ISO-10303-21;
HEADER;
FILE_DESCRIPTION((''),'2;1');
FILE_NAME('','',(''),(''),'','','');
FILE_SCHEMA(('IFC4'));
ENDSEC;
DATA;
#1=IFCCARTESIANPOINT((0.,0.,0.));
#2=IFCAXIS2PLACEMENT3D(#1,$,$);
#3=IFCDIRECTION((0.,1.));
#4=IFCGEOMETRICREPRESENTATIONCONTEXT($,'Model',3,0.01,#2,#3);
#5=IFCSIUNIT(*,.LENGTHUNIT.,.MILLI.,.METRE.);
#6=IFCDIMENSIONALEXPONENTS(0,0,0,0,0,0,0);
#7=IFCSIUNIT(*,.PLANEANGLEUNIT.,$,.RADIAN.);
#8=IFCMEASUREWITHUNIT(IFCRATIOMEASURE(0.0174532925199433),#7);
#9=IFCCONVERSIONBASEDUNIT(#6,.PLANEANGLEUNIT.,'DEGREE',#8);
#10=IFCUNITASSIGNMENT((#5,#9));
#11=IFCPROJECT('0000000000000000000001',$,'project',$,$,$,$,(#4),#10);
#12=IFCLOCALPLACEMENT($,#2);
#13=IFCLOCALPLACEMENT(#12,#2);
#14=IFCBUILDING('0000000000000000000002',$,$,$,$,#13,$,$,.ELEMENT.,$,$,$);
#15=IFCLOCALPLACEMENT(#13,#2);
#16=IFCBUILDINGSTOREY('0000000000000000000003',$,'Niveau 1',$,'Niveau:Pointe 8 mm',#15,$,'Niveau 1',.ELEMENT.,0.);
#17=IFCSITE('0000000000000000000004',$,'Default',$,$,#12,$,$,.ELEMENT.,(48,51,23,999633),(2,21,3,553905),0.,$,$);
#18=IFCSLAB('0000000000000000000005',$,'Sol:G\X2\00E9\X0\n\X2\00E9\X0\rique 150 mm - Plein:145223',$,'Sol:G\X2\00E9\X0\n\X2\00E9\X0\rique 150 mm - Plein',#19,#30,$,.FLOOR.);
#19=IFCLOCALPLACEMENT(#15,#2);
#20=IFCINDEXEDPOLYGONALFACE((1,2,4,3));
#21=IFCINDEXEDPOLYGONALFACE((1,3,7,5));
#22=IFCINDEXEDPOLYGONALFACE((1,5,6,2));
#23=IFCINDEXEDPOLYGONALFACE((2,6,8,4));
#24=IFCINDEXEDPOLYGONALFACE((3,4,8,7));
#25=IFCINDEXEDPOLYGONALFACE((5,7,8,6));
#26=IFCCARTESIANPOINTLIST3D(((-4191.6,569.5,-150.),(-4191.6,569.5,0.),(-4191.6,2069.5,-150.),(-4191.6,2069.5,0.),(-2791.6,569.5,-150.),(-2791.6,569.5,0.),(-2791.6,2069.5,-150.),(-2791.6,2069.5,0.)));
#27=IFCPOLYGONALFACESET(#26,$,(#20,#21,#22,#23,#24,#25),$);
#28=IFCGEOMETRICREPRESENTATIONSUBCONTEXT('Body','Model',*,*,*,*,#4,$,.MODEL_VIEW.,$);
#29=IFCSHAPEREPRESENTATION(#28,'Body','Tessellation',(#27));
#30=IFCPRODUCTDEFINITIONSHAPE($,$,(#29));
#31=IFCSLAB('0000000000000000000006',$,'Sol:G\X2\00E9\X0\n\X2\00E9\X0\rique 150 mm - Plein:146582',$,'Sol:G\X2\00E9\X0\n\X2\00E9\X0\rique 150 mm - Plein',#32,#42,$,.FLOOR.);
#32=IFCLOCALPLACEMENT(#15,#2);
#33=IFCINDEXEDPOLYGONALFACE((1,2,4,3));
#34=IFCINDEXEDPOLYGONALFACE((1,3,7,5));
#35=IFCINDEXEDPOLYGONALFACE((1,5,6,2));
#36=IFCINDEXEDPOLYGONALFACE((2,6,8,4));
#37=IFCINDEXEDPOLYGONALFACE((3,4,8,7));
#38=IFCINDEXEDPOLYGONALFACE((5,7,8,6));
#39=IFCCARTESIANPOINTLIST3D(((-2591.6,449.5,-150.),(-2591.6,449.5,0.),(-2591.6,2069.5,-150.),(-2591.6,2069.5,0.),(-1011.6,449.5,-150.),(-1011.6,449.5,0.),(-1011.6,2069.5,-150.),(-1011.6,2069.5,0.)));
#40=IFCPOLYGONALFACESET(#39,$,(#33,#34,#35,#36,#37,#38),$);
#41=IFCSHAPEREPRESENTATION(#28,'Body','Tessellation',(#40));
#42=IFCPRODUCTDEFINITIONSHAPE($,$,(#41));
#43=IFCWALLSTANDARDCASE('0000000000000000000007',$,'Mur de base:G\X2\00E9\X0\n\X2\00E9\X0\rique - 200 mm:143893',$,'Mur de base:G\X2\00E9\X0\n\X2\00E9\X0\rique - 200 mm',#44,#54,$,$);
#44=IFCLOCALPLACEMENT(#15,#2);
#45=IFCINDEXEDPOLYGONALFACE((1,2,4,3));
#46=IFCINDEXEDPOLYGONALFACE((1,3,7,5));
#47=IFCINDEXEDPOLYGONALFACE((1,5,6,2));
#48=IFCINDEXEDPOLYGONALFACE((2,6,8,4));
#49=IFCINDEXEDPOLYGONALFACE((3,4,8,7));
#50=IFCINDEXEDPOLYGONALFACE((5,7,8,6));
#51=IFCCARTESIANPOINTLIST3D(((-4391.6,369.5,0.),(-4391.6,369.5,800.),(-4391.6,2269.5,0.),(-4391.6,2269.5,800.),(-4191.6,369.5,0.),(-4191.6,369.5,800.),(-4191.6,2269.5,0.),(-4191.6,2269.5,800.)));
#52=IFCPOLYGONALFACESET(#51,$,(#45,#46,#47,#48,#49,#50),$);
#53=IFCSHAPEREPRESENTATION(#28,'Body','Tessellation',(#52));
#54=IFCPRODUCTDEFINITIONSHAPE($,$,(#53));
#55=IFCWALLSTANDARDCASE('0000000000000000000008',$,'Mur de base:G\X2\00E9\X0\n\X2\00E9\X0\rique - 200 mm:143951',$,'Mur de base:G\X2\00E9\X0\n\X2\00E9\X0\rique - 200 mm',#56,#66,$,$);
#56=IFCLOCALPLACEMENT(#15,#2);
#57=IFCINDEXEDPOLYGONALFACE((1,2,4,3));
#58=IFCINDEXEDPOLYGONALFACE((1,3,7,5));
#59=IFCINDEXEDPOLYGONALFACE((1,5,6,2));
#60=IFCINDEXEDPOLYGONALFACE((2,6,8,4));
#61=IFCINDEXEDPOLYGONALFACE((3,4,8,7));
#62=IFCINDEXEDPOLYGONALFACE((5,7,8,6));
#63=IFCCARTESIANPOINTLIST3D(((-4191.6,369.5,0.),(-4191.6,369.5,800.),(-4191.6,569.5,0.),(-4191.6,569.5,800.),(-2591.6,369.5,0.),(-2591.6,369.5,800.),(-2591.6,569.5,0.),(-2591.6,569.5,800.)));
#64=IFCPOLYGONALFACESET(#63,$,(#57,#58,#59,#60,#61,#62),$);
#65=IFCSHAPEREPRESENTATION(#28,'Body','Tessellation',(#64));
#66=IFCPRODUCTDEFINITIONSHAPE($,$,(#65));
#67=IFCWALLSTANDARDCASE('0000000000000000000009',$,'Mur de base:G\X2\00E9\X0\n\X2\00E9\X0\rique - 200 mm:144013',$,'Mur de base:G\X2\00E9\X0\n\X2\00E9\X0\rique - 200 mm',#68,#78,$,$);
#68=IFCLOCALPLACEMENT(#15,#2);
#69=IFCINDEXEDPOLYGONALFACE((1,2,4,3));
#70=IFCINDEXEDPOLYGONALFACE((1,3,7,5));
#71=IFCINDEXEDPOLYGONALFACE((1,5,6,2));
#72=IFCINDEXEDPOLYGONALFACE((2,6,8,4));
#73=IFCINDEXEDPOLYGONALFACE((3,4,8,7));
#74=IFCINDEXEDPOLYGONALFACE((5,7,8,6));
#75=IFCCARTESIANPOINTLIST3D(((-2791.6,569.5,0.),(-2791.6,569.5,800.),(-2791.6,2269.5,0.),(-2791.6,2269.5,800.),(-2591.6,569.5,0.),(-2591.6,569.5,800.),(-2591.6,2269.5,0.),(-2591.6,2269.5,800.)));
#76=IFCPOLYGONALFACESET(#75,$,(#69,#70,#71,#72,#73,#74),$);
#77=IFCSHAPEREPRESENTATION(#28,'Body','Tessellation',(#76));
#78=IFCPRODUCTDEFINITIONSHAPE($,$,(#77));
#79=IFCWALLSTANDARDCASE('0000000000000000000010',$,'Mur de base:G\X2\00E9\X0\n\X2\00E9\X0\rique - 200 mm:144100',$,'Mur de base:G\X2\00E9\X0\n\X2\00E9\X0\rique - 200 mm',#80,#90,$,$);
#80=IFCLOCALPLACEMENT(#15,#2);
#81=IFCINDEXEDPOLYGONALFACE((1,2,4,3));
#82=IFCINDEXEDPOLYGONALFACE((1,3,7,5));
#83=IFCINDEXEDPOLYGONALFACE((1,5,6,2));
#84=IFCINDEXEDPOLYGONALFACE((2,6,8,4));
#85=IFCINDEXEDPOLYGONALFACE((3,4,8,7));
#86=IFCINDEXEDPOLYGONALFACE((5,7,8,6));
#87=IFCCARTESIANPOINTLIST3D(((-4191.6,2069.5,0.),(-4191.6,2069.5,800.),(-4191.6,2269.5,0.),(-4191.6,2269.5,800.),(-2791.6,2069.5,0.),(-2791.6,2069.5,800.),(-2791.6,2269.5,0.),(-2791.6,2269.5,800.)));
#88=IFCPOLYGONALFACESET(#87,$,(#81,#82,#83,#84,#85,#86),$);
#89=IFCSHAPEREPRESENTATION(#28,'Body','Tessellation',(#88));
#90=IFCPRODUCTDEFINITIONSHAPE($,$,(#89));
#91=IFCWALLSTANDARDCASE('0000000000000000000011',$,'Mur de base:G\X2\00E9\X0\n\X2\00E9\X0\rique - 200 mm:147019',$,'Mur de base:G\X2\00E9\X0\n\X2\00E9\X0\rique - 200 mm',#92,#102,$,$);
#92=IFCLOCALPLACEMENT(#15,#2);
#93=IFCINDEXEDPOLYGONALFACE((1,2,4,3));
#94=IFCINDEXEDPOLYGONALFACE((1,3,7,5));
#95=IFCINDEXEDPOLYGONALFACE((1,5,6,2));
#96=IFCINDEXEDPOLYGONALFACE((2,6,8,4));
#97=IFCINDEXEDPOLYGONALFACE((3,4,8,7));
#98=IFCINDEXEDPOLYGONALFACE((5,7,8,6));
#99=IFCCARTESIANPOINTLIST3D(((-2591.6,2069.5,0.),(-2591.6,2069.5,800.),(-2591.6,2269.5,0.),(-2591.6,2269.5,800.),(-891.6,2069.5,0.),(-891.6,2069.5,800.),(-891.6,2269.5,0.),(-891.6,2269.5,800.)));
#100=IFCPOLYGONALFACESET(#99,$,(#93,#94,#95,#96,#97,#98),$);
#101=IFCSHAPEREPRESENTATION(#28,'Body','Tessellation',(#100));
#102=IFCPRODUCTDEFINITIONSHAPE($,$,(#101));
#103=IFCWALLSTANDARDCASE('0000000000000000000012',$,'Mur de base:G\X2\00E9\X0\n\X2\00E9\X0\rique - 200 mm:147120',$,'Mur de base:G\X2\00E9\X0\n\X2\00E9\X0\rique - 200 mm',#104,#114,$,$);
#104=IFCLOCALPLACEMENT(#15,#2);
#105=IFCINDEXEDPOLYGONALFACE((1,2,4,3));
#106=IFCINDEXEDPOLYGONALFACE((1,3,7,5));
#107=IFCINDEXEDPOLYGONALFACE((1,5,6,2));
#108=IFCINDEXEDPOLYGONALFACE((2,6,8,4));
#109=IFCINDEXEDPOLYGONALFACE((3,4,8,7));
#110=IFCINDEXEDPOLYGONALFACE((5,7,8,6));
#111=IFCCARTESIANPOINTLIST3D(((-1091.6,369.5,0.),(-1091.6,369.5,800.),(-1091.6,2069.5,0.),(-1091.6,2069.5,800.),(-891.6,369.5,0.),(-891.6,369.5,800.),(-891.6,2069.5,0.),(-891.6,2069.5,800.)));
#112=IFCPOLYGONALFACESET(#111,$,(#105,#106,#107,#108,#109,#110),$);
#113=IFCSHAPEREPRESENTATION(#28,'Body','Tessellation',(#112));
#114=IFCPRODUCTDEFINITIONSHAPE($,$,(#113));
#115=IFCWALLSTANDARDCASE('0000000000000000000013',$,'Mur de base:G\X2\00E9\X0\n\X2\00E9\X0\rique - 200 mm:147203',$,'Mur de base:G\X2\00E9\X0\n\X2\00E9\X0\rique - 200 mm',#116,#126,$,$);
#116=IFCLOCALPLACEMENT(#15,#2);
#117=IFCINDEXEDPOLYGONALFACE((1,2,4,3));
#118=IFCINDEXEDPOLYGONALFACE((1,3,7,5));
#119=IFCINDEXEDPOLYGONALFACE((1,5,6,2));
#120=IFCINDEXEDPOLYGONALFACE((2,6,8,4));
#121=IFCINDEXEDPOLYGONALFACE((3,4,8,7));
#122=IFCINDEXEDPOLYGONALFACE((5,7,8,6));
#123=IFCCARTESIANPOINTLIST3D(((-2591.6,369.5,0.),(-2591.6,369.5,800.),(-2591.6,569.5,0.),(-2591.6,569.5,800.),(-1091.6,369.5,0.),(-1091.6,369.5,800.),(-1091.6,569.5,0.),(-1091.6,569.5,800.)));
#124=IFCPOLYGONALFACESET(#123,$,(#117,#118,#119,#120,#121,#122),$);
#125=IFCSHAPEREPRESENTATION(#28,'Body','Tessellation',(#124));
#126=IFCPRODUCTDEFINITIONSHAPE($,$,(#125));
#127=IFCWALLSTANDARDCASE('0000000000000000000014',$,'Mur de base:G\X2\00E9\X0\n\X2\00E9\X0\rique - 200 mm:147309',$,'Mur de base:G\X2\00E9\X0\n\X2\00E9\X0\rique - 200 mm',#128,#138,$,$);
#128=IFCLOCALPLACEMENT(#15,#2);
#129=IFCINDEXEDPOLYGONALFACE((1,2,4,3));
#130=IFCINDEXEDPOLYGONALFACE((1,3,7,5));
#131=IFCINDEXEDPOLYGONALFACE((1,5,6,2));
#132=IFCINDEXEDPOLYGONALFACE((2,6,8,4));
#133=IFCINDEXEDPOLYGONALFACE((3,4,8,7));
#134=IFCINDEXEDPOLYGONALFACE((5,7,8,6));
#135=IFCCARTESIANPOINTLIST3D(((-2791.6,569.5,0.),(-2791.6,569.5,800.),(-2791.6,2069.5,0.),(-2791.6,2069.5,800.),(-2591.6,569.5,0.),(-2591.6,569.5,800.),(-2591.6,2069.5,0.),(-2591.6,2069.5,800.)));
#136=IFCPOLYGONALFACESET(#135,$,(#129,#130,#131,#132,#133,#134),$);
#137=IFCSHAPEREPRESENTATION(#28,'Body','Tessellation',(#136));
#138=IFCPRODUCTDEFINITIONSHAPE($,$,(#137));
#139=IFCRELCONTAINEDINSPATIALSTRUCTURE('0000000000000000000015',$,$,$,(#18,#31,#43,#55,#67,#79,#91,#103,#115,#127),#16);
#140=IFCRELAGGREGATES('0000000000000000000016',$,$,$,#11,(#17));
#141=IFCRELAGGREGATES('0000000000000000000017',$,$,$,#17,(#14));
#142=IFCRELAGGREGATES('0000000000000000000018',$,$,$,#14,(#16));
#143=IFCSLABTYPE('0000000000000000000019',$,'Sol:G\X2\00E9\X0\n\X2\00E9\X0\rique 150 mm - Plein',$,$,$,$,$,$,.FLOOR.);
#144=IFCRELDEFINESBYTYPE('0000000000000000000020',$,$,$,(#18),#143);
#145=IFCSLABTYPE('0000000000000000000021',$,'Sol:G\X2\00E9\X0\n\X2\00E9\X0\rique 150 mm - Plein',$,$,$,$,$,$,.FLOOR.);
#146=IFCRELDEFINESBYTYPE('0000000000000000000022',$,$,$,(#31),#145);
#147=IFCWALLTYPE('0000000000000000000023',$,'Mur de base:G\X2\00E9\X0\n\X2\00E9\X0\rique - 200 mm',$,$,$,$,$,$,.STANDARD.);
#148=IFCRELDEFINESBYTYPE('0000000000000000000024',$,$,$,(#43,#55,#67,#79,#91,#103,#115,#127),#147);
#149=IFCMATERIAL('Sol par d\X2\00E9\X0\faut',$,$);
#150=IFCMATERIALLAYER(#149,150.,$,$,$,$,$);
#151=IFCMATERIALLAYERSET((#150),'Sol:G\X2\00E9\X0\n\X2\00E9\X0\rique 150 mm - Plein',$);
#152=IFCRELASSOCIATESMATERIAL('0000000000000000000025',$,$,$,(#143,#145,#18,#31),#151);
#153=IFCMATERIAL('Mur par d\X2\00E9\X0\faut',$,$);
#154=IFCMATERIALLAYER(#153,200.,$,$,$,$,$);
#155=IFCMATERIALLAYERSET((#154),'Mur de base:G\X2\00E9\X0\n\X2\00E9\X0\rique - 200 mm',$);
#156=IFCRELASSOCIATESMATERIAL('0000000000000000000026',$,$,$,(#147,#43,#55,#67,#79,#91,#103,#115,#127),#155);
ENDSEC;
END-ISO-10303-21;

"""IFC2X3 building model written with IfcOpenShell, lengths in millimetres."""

from ifc_helpers import new_model, entity, si_unit, converted_unit, direction, frame, frame_2d, origin, origin_2d_with_axis, place, context, subcontext, project, spatial, rectangle, extrude, material, layer, layer_set, layer_usage, type_object, element, save


model = new_model("IFC2X3")

# Units and contexts
model_context = context("Model", 3, precision=0.01, world=origin(), true_north=direction((0.0, 1.0)))
body_context = subcontext(model_context, "Body", "Model", "MODEL_VIEW")
ifc_project = project(units=[si_unit("LENGTHUNIT", "METRE", prefix="MILLI"), converted_unit("PLANEANGLEUNIT", "DEGREE", entity("IfcRatioMeasure", 0.0174532925199433), si_unit("PLANEANGLEUNIT", "RADIAN"), dimensions=[0, 0, 0, 0, 0, 0, 0])], contexts=[model_context])

# Site, building, storey
site_placement = place(None, origin())
site = spatial("IfcSite", under=ifc_project, at=site_placement, Name="Default", CompositionType="ELEMENT", RefLatitude=(48, 51, 23, 999633), RefLongitude=(2, 21, 3, 553905), RefElevation=0.0)
building_placement = place(site_placement, origin())
building = spatial("IfcBuilding", under=site, at=building_placement, CompositionType="ELEMENT")
storey_placement = place(building_placement, origin())
storey = spatial("IfcBuildingStorey", under=building, at=storey_placement, Name="Niveau 1", ObjectType="Niveau:Pointe 8 mm", LongName="Niveau 1", CompositionType="ELEMENT", Elevation=0.0)

# Slabs
ifc_material_1 = material(Name="Sol par défaut")
ifc_layer_1 = layer(ifc_material_1, 150.0)
ifc_layer_set_1 = layer_set([ifc_layer_1], Name="Sol:Générique 150 mm - Plein")
ifc_layer_usage_1 = layer_usage(ifc_layer_set_1, "AXIS3", "POSITIVE", 0.0)
slab_type_1 = type_object("IfcSlabType", Name="Sol:Générique 150 mm - Plein", PredefinedType="FLOOR", material=ifc_layer_set_1)
slab_1_placement = place(storey_placement, origin())
element("IfcSlab", 1, at=slab_1_placement, inside=storey, type_object=slab_type_1, material=ifc_layer_usage_1, Name="Sol:Générique 150 mm - Plein:145223", ObjectType="Sol:Générique 150 mm - Plein", PredefinedType="FLOOR", context=body_context, shape_type="SweptSolid", body=[
    extrude(rectangle(XDim=1500.0, YDim=1400.0, at=frame_2d((0.0, 0.0), x_axis=(1.0, 0.0))), frame((-3491.6, 1319.5, 0.0), z_axis=(0.0, 0.0, -1.0), x_axis=(0.0, 1.0, 0.0)), (0.0, 0.0, 1.0), 150.0),
])
ifc_layer_usage_2 = layer_usage(ifc_layer_set_1, "AXIS3", "POSITIVE", 0.0)
slab_type_2 = type_object("IfcSlabType", Name="Sol:Générique 150 mm - Plein", PredefinedType="FLOOR", material=ifc_layer_set_1)
slab_2_placement = place(storey_placement, origin())
element("IfcSlab", 2, at=slab_2_placement, inside=storey, type_object=slab_type_2, material=ifc_layer_usage_2, Name="Sol:Générique 150 mm - Plein:146582", ObjectType="Sol:Générique 150 mm - Plein", PredefinedType="FLOOR", context=body_context, shape_type="SweptSolid", body=[
    extrude(rectangle(XDim=1620.0, YDim=1580.0, at=origin_2d_with_axis()), frame((-1801.6, 1259.5, 0.0), z_axis=(0.0, 0.0, -1.0), x_axis=(0.0, 1.0, 0.0)), (0.0, 0.0, 1.0), 150.0),
])

# Walls
ifc_material_2 = material(Name="Mur par défaut")
ifc_layer_2 = layer(ifc_material_2, 200.0)
ifc_layer_set_2 = layer_set([ifc_layer_2], Name="Mur de base:Générique - 200 mm")
ifc_layer_usage_3 = layer_usage(ifc_layer_set_2, "AXIS2", "NEGATIVE", 100.0)
wall_type = type_object("IfcWallType", Name="Mur de base:Générique - 200 mm", PredefinedType="STANDARD", material=ifc_layer_set_2)
wall_1_placement = place(storey_placement, frame((-4291.6, 2269.5, 0.0), z_axis=(0.0, 0.0, 1.0), x_axis=(0.0, -1.0, 0.0)))
element("IfcWallStandardCase", 3, at=wall_1_placement, inside=storey, type_object=wall_type, material=ifc_layer_usage_3, Name="Mur de base:Générique - 200 mm:143893", ObjectType="Mur de base:Générique - 200 mm", context=body_context, shape_type="SweptSolid", body=[
    extrude(rectangle(XDim=1900.0, YDim=200.0, at=frame_2d((950.0, 0.0), x_axis=(-1.0, 0.0))), origin(), (0.0, 0.0, 1.0), 800.0),
])
ifc_layer_usage_4 = layer_usage(ifc_layer_set_2, "AXIS2", "NEGATIVE", 100.0)
wall_2_placement = place(storey_placement, frame((-4191.6, 469.5, 0.0)))
element("IfcWallStandardCase", 4, at=wall_2_placement, inside=storey, type_object=wall_type, material=ifc_layer_usage_4, Name="Mur de base:Générique - 200 mm:143951", ObjectType="Mur de base:Générique - 200 mm", context=body_context, shape_type="SweptSolid", body=[
    extrude(rectangle(XDim=1600.0, YDim=200.0, at=frame_2d((800.0, 0.0), x_axis=(-1.0, 0.0))), origin(), (0.0, 0.0, 1.0), 800.0),
])
ifc_layer_usage_5 = layer_usage(ifc_layer_set_2, "AXIS2", "NEGATIVE", 100.0)
wall_3_placement = place(storey_placement, frame((-2691.6, 569.5, 0.0), z_axis=(0.0, 0.0, 1.0), x_axis=(0.0, 1.0, 0.0)))
element("IfcWallStandardCase", 5, at=wall_3_placement, inside=storey, type_object=wall_type, material=ifc_layer_usage_5, Name="Mur de base:Générique - 200 mm:144013", ObjectType="Mur de base:Générique - 200 mm", context=body_context, shape_type="SweptSolid", body=[
    extrude(rectangle(XDim=1700.0, YDim=200.0, at=frame_2d((850.0, 0.0), x_axis=(-1.0, 0.0))), origin(), (0.0, 0.0, 1.0), 800.0),
])
ifc_layer_usage_6 = layer_usage(ifc_layer_set_2, "AXIS2", "NEGATIVE", 100.0)
wall_4_placement = place(storey_placement, frame((-2791.6, 2169.5, 0.0), z_axis=(0.0, 0.0, 1.0), x_axis=(-1.0, 0.0, 0.0)))
element("IfcWallStandardCase", 6, at=wall_4_placement, inside=storey, type_object=wall_type, material=ifc_layer_usage_6, Name="Mur de base:Générique - 200 mm:144100", ObjectType="Mur de base:Générique - 200 mm", context=body_context, shape_type="SweptSolid", body=[
    extrude(rectangle(XDim=1400.0, YDim=200.0, at=frame_2d((700.0, 0.0), x_axis=(-1.0, 0.0))), origin(), (0.0, 0.0, 1.0), 800.0),
])
ifc_layer_usage_7 = layer_usage(ifc_layer_set_2, "AXIS2", "NEGATIVE", 100.0)
wall_5_placement = place(storey_placement, frame((-2591.6, 2169.5, 0.0)))
element("IfcWallStandardCase", 7, at=wall_5_placement, inside=storey, type_object=wall_type, material=ifc_layer_usage_7, Name="Mur de base:Générique - 200 mm:147019", ObjectType="Mur de base:Générique - 200 mm", context=body_context, shape_type="SweptSolid", body=[
    extrude(rectangle(XDim=1700.0, YDim=200.0, at=frame_2d((850.0, 0.0), x_axis=(-1.0, 0.0))), origin(), (0.0, 0.0, 1.0), 800.0),
])
ifc_layer_usage_8 = layer_usage(ifc_layer_set_2, "AXIS2", "NEGATIVE", 100.0)
wall_6_placement = place(storey_placement, frame((-991.6, 2069.5, 0.0), z_axis=(0.0, 0.0, 1.0), x_axis=(0.0, -1.0, 0.0)))
element("IfcWallStandardCase", 8, at=wall_6_placement, inside=storey, type_object=wall_type, material=ifc_layer_usage_8, Name="Mur de base:Générique - 200 mm:147120", ObjectType="Mur de base:Générique - 200 mm", context=body_context, shape_type="SweptSolid", body=[
    extrude(rectangle(XDim=1700.0, YDim=200.0, at=frame_2d((850.0, 0.0), x_axis=(-1.0, 0.0))), origin(), (0.0, 0.0, 1.0), 800.0),
])
ifc_layer_usage_9 = layer_usage(ifc_layer_set_2, "AXIS2", "NEGATIVE", 100.0)
wall_7_placement = place(storey_placement, frame((-1091.6, 469.5, 0.0), z_axis=(0.0, 0.0, 1.0), x_axis=(-1.0, 0.0, 0.0)))
element("IfcWallStandardCase", 9, at=wall_7_placement, inside=storey, type_object=wall_type, material=ifc_layer_usage_9, Name="Mur de base:Générique - 200 mm:147203", ObjectType="Mur de base:Générique - 200 mm", context=body_context, shape_type="SweptSolid", body=[
    extrude(rectangle(XDim=1500.0, YDim=200.0, at=frame_2d((750.0, 0.0), x_axis=(-1.0, 0.0))), origin(), (0.0, 0.0, 1.0), 800.0),
])
ifc_layer_usage_10 = layer_usage(ifc_layer_set_2, "AXIS2", "NEGATIVE", 100.0)
wall_8_placement = place(storey_placement, frame((-2691.6, 569.5, 0.0), z_axis=(0.0, 0.0, 1.0), x_axis=(0.0, 1.0, 0.0)))
element("IfcWallStandardCase", 10, at=wall_8_placement, inside=storey, type_object=wall_type, material=ifc_layer_usage_10, Name="Mur de base:Générique - 200 mm:147309", ObjectType="Mur de base:Générique - 200 mm", context=body_context, shape_type="SweptSolid", body=[
    extrude(rectangle(XDim=1500.0, YDim=200.0, at=frame_2d((750.0, 0.0), x_axis=(-1.0, 0.0))), origin(), (0.0, 0.0, 1.0), 800.0),
])

save(model, "model.ifc")
